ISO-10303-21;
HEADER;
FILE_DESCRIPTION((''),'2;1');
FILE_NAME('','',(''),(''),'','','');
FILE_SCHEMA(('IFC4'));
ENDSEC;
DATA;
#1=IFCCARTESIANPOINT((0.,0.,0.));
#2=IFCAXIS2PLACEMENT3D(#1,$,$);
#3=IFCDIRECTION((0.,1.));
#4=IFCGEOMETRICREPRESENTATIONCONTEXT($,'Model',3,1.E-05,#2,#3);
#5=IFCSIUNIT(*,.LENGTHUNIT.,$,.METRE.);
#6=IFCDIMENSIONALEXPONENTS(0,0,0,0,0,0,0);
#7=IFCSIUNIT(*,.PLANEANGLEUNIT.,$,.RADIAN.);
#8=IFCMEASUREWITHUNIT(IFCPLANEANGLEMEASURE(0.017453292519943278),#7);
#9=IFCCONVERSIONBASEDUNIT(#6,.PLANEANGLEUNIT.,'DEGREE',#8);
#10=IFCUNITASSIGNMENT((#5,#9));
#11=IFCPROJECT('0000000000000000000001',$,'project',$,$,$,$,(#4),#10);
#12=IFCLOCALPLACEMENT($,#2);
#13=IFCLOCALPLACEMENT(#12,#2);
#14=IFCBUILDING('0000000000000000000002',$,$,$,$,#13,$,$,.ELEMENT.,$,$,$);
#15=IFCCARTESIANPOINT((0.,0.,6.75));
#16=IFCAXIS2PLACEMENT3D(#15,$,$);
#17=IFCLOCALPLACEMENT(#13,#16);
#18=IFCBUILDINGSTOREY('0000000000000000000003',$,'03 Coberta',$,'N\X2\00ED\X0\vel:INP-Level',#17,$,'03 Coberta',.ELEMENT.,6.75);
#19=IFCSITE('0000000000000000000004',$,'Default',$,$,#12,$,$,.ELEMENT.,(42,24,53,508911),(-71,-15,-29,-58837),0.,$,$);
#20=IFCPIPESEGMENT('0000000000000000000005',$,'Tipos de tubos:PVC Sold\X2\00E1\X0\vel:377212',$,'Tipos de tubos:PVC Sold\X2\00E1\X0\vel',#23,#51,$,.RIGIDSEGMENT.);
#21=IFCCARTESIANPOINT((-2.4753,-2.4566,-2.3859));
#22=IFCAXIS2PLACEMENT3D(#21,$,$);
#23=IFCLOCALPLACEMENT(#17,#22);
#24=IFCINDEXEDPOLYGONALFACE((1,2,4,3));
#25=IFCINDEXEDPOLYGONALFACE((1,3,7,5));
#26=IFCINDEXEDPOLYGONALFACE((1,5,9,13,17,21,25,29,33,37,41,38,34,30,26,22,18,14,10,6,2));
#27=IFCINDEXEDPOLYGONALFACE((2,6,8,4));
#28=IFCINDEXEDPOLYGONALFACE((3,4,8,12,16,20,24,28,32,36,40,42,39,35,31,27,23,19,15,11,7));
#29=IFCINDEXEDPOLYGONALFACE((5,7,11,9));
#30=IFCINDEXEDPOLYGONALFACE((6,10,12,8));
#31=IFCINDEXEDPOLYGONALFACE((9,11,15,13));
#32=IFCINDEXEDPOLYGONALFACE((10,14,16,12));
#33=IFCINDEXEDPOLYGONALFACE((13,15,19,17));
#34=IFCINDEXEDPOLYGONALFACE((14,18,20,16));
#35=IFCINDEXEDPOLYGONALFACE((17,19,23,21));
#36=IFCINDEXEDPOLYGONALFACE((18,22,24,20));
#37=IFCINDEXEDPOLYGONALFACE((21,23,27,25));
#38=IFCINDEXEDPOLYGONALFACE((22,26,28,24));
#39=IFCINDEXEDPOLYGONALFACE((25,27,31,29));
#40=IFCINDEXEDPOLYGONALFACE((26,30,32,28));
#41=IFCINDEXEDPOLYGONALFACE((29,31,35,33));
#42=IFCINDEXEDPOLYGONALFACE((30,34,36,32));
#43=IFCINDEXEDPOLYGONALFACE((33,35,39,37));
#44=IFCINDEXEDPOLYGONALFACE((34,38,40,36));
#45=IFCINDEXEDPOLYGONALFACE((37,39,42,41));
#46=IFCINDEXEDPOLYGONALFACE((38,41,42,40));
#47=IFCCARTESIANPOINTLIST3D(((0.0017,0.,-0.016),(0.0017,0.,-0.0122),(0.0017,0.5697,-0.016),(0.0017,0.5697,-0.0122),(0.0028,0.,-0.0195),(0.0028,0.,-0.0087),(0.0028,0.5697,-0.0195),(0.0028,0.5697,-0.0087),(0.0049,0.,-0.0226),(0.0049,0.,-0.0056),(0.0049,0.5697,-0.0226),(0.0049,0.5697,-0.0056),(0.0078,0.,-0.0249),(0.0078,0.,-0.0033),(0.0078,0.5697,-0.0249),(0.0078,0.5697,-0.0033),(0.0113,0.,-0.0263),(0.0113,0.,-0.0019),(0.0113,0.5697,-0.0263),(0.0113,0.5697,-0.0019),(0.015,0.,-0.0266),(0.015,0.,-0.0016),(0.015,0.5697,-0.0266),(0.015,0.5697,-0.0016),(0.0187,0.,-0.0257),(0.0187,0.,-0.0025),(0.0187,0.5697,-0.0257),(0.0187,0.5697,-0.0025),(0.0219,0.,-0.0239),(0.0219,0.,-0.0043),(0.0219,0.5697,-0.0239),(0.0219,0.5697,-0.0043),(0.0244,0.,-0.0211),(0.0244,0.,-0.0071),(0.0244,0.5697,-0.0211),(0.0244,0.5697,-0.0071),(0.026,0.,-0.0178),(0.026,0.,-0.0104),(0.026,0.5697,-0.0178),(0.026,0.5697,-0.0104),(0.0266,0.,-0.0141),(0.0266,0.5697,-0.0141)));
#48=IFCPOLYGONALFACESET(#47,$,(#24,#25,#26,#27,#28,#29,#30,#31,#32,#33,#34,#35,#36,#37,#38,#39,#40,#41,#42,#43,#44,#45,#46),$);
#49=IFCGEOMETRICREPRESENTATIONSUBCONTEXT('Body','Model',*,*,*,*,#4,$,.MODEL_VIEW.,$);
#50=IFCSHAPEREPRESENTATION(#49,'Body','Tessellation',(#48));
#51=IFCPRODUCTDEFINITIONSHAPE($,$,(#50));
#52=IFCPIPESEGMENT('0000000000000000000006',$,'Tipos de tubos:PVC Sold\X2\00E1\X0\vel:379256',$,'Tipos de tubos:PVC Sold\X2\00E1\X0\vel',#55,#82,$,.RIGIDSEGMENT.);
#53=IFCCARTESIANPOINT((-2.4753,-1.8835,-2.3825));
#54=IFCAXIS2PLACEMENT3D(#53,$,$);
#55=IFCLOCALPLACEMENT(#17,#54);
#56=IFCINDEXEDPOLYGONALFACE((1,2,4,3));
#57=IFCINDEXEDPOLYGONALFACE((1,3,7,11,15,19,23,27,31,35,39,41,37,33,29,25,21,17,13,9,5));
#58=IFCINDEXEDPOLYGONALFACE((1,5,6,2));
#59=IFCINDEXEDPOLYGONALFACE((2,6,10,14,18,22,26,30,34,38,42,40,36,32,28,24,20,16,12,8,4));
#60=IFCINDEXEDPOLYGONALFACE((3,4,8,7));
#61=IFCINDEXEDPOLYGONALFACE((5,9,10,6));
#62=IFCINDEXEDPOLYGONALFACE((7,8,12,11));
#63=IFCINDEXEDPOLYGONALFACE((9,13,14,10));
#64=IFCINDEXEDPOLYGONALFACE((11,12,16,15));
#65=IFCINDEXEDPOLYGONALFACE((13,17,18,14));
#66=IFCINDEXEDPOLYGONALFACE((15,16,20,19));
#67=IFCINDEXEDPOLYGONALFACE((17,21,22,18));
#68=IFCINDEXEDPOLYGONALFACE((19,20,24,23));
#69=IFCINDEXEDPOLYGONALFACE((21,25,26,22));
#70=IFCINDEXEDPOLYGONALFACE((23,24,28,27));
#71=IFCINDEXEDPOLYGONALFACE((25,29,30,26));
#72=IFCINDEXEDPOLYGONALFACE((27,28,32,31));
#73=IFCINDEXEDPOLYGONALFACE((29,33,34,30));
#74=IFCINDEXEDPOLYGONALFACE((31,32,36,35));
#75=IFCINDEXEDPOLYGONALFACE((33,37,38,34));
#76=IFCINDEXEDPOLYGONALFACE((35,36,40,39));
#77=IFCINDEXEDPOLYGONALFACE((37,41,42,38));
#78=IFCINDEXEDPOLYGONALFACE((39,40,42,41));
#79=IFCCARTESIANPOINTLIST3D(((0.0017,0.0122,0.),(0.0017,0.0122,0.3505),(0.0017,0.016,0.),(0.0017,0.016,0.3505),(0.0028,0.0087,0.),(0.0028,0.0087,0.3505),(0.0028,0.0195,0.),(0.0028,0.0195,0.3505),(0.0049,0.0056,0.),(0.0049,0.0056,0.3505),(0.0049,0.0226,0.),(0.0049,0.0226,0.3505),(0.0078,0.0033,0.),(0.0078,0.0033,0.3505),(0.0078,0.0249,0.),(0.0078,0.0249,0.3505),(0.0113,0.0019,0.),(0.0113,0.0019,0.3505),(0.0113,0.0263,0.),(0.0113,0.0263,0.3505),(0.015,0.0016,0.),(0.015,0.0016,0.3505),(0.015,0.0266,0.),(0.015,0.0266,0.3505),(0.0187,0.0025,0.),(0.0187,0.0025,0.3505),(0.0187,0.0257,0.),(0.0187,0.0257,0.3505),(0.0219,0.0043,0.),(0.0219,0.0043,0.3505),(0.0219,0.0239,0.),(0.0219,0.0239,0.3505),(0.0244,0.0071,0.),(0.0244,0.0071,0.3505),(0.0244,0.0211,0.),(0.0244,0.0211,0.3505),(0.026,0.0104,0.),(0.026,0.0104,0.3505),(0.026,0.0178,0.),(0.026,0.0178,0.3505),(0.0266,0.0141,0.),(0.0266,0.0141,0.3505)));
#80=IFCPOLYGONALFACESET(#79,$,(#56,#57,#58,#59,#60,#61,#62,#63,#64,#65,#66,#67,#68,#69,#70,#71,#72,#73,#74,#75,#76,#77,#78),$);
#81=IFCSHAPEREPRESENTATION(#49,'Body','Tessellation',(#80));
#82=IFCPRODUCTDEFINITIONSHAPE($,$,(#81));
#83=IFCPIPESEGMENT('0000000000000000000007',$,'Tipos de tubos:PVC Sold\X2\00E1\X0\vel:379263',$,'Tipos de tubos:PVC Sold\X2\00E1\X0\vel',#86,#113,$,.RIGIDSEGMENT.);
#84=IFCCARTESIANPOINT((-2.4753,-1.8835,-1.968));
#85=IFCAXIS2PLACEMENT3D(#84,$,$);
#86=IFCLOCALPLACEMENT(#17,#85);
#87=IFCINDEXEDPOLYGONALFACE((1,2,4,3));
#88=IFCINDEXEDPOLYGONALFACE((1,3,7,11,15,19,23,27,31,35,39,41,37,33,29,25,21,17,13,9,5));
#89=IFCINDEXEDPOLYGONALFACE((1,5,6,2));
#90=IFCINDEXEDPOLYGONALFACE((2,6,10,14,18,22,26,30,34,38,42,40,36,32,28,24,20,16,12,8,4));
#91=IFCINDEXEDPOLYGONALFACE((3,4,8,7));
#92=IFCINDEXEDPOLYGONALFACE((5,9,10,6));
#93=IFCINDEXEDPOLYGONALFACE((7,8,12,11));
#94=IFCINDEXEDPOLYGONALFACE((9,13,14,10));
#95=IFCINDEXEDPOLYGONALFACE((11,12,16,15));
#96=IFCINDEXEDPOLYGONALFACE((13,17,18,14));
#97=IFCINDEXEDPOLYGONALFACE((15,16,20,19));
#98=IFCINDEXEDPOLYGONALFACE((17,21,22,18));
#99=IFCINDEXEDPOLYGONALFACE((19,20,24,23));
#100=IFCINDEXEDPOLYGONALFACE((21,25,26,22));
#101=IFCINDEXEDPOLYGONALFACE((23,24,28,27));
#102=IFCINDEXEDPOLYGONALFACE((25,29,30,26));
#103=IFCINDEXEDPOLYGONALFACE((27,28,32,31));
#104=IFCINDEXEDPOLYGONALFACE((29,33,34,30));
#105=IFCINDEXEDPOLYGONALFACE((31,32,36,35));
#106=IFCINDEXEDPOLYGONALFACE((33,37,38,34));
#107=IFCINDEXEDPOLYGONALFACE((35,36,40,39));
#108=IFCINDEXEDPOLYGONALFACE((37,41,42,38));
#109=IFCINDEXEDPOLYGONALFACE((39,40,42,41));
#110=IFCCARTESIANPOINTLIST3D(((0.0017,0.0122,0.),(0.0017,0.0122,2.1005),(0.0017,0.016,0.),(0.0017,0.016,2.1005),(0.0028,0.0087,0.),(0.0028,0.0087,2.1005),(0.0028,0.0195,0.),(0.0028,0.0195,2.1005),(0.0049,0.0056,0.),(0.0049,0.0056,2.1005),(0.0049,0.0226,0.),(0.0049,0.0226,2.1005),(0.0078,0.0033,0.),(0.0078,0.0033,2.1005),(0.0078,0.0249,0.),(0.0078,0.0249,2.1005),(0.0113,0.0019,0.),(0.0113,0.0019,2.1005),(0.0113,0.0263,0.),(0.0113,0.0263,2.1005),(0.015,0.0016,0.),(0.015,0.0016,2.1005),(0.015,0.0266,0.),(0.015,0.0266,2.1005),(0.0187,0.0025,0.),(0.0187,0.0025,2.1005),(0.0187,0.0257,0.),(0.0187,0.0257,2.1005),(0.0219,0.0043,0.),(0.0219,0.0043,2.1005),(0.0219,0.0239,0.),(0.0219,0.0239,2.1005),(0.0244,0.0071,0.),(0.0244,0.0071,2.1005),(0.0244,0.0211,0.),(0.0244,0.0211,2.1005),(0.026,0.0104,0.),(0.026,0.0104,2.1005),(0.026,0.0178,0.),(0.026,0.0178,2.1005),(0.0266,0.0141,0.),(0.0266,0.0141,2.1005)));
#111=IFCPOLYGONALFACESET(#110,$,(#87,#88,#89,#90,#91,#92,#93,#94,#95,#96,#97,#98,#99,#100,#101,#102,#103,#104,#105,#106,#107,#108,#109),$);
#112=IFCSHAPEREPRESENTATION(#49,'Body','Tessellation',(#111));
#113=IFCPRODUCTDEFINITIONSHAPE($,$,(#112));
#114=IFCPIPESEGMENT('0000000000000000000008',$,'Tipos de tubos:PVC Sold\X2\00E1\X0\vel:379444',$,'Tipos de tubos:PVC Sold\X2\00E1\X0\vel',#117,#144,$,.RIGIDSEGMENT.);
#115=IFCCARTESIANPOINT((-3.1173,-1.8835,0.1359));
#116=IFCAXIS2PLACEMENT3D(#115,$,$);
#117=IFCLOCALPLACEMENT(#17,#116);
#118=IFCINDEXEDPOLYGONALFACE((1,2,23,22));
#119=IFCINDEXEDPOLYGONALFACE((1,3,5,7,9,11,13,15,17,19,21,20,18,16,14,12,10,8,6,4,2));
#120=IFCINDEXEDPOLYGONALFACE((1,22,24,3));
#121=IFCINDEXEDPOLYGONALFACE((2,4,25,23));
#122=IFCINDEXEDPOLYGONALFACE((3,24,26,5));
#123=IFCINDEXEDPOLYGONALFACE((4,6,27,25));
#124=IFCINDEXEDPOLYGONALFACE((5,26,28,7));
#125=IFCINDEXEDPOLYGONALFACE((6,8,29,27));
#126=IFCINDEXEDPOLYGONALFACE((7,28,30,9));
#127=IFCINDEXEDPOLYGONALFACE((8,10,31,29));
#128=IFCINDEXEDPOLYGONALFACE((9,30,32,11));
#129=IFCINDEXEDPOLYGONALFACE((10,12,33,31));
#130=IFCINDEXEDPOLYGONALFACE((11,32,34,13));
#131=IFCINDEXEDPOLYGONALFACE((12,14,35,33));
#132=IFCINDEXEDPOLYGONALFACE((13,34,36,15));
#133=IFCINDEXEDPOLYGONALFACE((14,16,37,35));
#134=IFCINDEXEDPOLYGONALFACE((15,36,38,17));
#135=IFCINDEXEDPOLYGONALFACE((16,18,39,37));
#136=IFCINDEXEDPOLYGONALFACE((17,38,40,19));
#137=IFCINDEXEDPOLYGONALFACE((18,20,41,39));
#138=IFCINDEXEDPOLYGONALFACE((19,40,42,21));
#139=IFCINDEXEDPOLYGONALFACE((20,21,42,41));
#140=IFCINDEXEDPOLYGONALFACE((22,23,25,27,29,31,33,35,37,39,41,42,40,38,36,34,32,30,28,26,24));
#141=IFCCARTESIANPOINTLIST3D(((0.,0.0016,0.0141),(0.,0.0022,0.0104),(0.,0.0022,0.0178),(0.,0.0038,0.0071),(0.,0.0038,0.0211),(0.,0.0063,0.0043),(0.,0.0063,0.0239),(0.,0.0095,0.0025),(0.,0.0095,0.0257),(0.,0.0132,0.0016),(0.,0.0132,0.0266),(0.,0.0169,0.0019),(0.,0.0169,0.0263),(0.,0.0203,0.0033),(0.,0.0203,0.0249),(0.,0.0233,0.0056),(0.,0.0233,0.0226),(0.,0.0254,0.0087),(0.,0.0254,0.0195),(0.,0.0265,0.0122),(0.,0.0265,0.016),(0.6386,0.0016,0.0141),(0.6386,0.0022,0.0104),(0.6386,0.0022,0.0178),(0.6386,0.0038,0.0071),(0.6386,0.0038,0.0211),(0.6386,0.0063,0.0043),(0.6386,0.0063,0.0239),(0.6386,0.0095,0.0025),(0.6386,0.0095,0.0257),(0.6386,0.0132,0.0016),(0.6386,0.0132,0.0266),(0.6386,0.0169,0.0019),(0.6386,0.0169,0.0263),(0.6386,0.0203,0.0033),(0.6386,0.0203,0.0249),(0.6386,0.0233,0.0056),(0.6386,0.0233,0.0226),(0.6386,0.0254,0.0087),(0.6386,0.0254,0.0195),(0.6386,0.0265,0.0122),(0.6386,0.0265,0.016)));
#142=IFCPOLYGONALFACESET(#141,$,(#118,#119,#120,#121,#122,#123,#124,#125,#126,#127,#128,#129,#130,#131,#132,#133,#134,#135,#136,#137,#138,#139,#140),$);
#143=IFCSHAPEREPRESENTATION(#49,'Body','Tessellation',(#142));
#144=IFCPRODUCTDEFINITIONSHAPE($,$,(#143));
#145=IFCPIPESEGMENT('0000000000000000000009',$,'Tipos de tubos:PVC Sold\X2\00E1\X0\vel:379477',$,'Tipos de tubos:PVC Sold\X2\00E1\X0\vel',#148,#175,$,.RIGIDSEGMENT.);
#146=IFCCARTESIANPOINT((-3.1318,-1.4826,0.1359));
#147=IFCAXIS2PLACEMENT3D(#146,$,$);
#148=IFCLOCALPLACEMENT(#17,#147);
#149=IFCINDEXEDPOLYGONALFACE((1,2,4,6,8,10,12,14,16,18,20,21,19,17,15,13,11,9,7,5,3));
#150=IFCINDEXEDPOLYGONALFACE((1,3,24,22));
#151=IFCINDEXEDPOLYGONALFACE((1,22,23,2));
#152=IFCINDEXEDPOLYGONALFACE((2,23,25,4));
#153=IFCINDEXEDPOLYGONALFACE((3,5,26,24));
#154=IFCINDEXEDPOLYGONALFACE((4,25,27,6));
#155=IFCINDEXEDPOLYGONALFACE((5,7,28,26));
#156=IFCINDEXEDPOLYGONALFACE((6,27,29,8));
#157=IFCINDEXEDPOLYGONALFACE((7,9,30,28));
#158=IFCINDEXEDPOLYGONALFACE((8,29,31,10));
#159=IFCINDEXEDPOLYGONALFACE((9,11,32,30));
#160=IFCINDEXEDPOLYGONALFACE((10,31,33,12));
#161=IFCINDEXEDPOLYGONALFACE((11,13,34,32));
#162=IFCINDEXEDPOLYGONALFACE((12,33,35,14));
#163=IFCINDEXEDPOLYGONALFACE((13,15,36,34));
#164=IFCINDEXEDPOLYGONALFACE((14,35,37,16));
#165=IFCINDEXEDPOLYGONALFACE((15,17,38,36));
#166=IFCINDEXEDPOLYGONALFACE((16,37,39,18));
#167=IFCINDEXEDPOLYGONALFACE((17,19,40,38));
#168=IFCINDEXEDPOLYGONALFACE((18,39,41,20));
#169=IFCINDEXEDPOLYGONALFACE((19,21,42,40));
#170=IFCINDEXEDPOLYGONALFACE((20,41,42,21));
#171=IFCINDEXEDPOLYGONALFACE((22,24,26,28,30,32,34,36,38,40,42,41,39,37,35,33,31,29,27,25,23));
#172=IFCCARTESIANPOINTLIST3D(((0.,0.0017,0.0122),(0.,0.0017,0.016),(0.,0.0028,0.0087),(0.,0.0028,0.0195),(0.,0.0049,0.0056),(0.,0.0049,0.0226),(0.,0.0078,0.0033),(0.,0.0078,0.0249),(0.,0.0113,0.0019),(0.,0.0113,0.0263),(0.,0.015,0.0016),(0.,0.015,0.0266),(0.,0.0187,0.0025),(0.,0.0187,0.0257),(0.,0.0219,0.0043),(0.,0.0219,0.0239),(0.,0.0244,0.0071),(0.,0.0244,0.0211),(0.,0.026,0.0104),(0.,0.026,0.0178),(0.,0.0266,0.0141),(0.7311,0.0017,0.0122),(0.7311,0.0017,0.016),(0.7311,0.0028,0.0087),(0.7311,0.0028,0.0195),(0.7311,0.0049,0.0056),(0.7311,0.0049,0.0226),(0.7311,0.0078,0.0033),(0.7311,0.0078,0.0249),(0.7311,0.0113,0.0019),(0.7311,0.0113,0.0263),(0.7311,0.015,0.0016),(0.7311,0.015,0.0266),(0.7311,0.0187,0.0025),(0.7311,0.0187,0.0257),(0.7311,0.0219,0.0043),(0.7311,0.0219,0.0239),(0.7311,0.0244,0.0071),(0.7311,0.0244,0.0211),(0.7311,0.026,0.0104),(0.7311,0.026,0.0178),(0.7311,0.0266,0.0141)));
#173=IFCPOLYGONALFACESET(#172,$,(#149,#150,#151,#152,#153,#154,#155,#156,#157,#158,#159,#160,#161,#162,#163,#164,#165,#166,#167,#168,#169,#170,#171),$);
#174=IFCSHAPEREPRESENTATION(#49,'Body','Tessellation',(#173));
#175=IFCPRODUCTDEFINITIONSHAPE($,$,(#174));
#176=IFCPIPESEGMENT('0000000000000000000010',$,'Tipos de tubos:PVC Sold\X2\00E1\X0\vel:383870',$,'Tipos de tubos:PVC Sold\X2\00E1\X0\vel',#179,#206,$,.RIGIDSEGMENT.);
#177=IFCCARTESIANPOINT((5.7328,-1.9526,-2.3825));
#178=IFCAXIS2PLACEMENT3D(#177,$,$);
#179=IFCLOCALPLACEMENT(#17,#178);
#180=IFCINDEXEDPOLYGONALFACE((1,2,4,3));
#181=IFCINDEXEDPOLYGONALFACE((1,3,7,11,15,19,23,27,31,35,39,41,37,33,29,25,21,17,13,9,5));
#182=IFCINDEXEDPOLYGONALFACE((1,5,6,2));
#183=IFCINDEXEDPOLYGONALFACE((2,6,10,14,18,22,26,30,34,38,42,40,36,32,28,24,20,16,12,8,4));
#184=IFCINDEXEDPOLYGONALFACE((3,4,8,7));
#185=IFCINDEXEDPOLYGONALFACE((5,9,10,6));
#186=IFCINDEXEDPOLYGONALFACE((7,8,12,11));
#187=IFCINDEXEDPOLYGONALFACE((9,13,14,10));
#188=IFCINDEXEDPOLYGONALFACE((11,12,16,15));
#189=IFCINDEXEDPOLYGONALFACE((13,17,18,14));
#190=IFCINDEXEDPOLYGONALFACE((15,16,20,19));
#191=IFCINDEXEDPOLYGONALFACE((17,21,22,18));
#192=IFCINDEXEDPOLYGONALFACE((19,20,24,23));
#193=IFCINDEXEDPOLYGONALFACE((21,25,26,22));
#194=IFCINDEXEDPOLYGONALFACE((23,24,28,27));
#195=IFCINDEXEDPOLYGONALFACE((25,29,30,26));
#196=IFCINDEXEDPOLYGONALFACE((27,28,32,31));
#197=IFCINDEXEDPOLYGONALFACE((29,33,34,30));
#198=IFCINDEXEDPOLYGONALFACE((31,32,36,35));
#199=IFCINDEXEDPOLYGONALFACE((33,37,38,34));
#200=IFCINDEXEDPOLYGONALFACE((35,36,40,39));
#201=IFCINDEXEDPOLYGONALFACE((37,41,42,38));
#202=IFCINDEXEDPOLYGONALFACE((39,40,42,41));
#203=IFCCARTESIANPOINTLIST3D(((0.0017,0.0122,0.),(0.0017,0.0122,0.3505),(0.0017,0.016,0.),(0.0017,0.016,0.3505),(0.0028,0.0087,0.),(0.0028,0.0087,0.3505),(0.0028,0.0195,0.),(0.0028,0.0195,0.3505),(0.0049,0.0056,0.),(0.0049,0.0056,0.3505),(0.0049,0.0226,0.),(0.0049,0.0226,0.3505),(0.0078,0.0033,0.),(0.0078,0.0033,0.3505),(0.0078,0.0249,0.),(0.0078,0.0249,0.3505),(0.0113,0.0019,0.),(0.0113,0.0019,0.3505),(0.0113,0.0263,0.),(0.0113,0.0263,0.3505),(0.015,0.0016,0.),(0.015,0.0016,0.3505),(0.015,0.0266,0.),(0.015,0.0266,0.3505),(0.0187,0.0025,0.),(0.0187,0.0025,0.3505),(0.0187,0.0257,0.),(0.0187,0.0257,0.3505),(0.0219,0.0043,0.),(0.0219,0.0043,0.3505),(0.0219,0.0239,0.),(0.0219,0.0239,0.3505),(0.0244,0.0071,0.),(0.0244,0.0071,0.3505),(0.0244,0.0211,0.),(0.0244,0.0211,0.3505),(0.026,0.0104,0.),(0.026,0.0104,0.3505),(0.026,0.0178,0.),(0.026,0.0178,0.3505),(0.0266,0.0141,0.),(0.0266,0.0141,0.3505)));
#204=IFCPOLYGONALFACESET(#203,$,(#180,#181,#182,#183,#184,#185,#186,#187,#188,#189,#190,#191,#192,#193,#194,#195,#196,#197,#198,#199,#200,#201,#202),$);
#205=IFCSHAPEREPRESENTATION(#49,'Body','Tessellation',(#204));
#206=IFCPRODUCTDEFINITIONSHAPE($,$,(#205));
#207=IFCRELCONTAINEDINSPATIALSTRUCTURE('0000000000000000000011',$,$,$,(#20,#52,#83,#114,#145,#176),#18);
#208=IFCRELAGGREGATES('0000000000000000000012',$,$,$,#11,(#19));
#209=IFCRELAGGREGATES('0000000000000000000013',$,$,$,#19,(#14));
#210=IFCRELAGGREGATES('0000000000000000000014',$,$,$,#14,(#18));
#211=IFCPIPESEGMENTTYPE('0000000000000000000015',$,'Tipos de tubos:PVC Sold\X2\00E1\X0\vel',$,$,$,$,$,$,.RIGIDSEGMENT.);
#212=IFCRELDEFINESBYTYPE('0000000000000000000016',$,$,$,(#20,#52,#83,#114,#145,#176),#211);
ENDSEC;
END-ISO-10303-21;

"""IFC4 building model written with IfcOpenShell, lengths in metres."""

from ifc_helpers import new_model, entity, si_unit, converted_unit, direction, frame, frame_2d, origin, origin_2d_with_axis, place, context, subcontext, project, spatial, circle, extrude, type_object, element, save


model = new_model("IFC4")

# Units and contexts
model_context = context("Model", 3, precision=1e-05, world=origin(), true_north=direction((0.0, 1.0)))
body_context = subcontext(model_context, "Body", "Model", "MODEL_VIEW")
ifc_project = project(units=[si_unit("LENGTHUNIT", "METRE"), converted_unit("PLANEANGLEUNIT", "DEGREE", entity("IfcPlaneAngleMeasure", 0.017453292519943278), si_unit("PLANEANGLEUNIT", "RADIAN"), dimensions=[0, 0, 0, 0, 0, 0, 0])], contexts=[model_context])

# Site, building, storey
site_placement = place(None, origin())
site = spatial("IfcSite", under=ifc_project, at=site_placement, Name="Default", CompositionType="ELEMENT", RefLatitude=(42, 24, 53, 508911), RefLongitude=(-71, -15, -29, -58837), RefElevation=0.0)
building_placement = place(site_placement, origin())
building = spatial("IfcBuilding", under=site, at=building_placement, CompositionType="ELEMENT")
storey_placement = place(building_placement, frame((0.0, 0.0, 6.75)))
storey = spatial("IfcBuildingStorey", under=building, at=storey_placement, Name="03 Coberta", ObjectType="Nível:INP-Level", LongName="03 Coberta", CompositionType="ELEMENT", Elevation=6.75)

# Pipe segments
pipe_segment_type = type_object("IfcPipeSegmentType", Name="Tipos de tubos:PVC Soldável", PredefinedType="RIGIDSEGMENT")
pipe_segment_1_placement = place(storey_placement, frame((-2.4753, -2.4566, -2.3859)))
element("IfcPipeSegment", 1, at=pipe_segment_1_placement, inside=storey, type_object=pipe_segment_type, Name="Tipos de tubos:PVC Soldável:377212", ObjectType="Tipos de tubos:PVC Soldável", PredefinedType="RIGIDSEGMENT", context=body_context, shape_type="SweptSolid", body=[
    extrude(circle(Radius=0.0125, at=origin_2d_with_axis()), frame((0.0141, 0.0, -0.0141), z_axis=(0.0, 1.0, 0.0), x_axis=(1.0, 0.0, 0.0)), (0.0, 0.0, 1.0), 0.5697),
])
pipe_segment_2_placement = place(storey_placement, frame((-2.4753, -1.8835, -2.3825)))
element("IfcPipeSegment", 2, at=pipe_segment_2_placement, inside=storey, type_object=pipe_segment_type, Name="Tipos de tubos:PVC Soldável:379256", ObjectType="Tipos de tubos:PVC Soldável", PredefinedType="RIGIDSEGMENT", context=body_context, shape_type="SweptSolid", body=[
    extrude(circle(Radius=0.0125, at=frame_2d((0.0, 0.0), x_axis=(1.0, 0.0))), frame((0.0141, 0.0141, 0.0)), (0.0, 0.0, 1.0), 0.3505),
])
pipe_segment_3_placement = place(storey_placement, frame((-2.4753, -1.8835, -1.968)))
element("IfcPipeSegment", 3, at=pipe_segment_3_placement, inside=storey, type_object=pipe_segment_type, Name="Tipos de tubos:PVC Soldável:379263", ObjectType="Tipos de tubos:PVC Soldável", PredefinedType="RIGIDSEGMENT", context=body_context, shape_type="SweptSolid", body=[
    extrude(circle(Radius=0.0125, at=origin_2d_with_axis()), frame((0.0141, 0.0141, 0.0)), (0.0, 0.0, 1.0), 2.1005),
])
pipe_segment_4_placement = place(storey_placement, frame((-3.1173, -1.8835, 0.1359)))
element("IfcPipeSegment", 4, at=pipe_segment_4_placement, inside=storey, type_object=pipe_segment_type, Name="Tipos de tubos:PVC Soldável:379444", ObjectType="Tipos de tubos:PVC Soldável", PredefinedType="RIGIDSEGMENT", context=body_context, shape_type="SweptSolid", body=[
    extrude(circle(Radius=0.0125, at=frame_2d((0.0, 0.0), x_axis=(1.0, 0.0))), frame((0.0, 0.0141, 0.0141), z_axis=(1.0, 0.0, 0.0), x_axis=(0.0, -1.0, 0.0)), (0.0, 0.0, 1.0), 0.6386),
])
pipe_segment_5_placement = place(storey_placement, frame((-3.1318, -1.4826, 0.1359)))
element("IfcPipeSegment", 5, at=pipe_segment_5_placement, inside=storey, type_object=pipe_segment_type, Name="Tipos de tubos:PVC Soldável:379477", ObjectType="Tipos de tubos:PVC Soldável", PredefinedType="RIGIDSEGMENT", context=body_context, shape_type="SweptSolid", body=[
    extrude(circle(Radius=0.0125, at=frame_2d((0.0, 0.0), x_axis=(1.0, 0.0))), frame((0.0, 0.0141, 0.0141), z_axis=(1.0, 0.0, 0.0), x_axis=(0.0, 1.0, 0.0)), (0.0, 0.0, 1.0), 0.7311),
])
pipe_segment_6_placement = place(storey_placement, frame((5.7328, -1.9526, -2.3825)))
element("IfcPipeSegment", 6, at=pipe_segment_6_placement, inside=storey, type_object=pipe_segment_type, Name="Tipos de tubos:PVC Soldável:383870", ObjectType="Tipos de tubos:PVC Soldável", PredefinedType="RIGIDSEGMENT", context=body_context, shape_type="SweptSolid", body=[
    extrude(circle(Radius=0.0125, at=origin_2d_with_axis()), frame((0.0141, 0.0141, 0.0)), (0.0, 0.0, 1.0), 0.3505),
])

save(model, "model.ifc")
